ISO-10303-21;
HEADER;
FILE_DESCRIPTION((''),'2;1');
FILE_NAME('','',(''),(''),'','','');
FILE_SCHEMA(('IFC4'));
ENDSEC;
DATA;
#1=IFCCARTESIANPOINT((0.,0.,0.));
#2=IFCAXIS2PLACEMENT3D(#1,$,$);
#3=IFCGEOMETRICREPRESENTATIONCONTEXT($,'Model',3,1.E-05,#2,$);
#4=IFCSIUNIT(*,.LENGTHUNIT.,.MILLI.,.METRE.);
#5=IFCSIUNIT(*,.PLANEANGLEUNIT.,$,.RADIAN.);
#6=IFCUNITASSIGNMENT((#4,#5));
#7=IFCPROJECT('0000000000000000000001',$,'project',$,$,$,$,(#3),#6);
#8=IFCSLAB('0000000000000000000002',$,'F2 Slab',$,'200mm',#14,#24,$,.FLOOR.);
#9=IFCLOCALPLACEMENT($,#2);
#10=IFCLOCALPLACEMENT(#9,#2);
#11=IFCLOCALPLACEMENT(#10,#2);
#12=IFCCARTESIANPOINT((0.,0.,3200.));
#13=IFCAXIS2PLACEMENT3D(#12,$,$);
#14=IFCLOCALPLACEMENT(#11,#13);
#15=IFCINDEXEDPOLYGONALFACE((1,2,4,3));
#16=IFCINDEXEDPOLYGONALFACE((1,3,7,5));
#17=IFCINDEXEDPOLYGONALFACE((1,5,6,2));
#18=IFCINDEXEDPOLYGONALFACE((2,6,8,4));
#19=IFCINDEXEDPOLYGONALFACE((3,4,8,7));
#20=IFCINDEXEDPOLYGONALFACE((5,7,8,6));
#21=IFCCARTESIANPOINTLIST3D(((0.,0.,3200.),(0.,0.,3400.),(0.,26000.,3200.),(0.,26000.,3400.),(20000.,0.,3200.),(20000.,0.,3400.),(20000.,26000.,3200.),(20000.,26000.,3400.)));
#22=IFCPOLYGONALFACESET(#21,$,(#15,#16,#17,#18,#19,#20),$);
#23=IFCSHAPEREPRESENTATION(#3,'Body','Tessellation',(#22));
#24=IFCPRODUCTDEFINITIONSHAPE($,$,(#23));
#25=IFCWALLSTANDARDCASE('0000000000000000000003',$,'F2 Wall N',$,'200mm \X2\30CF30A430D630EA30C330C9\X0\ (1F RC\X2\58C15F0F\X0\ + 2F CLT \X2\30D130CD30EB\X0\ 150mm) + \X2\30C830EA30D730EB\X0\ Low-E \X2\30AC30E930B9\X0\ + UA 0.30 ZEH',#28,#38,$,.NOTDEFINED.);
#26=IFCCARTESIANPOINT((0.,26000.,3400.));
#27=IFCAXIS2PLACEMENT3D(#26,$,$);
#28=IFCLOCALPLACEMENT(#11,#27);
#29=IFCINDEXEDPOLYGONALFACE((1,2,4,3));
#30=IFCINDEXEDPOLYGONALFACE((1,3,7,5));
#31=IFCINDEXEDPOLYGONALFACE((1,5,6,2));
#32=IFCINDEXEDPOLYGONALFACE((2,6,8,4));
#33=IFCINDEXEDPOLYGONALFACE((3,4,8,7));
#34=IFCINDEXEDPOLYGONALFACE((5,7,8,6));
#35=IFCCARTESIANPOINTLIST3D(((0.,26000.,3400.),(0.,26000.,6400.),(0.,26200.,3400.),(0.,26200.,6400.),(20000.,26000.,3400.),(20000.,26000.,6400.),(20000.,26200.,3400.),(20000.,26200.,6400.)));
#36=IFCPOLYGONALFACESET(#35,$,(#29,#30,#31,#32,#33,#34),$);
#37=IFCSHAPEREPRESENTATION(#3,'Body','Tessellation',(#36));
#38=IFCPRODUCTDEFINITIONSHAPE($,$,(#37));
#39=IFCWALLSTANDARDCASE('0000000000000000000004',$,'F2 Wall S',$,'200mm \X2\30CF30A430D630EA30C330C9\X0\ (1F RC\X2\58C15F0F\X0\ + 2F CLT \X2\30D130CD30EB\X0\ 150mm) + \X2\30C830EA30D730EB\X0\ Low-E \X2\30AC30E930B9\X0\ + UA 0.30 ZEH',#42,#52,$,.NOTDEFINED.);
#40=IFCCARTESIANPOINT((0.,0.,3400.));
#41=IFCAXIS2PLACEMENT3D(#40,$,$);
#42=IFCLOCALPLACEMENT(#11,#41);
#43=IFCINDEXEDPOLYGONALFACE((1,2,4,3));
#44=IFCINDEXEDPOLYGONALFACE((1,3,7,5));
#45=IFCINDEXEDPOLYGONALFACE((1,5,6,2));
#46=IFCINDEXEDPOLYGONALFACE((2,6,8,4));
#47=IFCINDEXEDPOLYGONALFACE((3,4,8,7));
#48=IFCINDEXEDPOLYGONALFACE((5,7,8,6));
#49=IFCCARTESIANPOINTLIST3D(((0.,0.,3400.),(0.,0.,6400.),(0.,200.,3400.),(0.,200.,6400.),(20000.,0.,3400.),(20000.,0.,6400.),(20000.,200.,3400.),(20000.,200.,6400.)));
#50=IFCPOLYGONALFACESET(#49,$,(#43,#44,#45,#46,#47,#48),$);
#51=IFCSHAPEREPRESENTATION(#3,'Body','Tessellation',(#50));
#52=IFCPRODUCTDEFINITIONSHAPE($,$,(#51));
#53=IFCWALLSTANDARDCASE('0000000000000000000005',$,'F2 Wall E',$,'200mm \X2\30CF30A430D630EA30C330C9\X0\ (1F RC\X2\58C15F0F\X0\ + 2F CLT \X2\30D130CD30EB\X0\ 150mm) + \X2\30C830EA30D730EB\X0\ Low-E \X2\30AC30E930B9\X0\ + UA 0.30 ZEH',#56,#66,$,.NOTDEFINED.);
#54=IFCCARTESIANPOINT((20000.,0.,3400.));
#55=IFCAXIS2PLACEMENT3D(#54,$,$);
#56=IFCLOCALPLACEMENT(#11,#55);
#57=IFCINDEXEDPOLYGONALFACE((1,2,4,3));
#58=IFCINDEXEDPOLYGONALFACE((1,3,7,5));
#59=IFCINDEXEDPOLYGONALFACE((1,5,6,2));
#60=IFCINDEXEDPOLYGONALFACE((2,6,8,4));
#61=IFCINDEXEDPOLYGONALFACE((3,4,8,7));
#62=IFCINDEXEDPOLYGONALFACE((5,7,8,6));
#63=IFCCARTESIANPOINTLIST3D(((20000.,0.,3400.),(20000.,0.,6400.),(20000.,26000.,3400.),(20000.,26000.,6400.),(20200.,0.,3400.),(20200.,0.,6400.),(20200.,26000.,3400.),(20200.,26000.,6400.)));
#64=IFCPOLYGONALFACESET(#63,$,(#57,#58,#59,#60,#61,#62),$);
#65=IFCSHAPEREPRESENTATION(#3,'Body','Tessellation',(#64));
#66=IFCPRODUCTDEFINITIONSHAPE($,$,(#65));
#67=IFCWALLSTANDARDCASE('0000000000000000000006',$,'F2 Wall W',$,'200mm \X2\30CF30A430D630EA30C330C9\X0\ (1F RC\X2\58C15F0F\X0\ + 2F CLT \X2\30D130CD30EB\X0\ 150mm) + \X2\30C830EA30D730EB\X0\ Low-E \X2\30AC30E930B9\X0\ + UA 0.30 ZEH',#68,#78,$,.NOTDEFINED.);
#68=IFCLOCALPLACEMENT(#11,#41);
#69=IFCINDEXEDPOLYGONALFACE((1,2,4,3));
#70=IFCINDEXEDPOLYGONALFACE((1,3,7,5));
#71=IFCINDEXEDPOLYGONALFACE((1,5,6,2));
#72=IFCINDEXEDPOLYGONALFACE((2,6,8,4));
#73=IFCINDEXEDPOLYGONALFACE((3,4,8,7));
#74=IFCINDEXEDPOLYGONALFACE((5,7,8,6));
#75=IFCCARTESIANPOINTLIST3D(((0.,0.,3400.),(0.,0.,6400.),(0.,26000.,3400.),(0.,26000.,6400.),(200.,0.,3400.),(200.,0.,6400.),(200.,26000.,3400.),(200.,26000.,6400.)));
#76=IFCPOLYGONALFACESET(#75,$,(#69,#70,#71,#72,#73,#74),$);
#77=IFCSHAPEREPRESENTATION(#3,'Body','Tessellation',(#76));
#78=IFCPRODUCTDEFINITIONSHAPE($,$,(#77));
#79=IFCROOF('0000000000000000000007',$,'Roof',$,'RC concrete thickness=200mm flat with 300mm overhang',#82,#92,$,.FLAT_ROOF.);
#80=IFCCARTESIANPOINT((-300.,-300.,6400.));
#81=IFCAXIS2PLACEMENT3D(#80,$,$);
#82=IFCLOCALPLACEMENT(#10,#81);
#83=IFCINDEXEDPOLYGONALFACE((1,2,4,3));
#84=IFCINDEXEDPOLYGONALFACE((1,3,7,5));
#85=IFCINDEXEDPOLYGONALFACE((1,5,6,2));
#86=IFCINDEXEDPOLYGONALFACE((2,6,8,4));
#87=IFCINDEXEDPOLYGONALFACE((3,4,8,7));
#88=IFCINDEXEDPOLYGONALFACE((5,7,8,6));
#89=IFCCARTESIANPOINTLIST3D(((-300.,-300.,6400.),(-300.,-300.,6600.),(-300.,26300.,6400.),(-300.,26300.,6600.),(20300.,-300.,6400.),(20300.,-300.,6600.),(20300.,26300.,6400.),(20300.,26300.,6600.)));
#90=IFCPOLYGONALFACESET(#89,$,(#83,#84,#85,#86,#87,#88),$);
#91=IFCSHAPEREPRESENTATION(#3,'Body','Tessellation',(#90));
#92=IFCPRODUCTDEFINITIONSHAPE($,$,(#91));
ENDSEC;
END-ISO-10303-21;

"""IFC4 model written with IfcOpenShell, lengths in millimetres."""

from ifc_helpers import new_model, si_unit, frame, frame_2d, origin, place, context, project, rectangle, extrude, element, save


model = new_model("IFC4")

# Units and contexts
model_context = context("Model", 3, precision=1e-05, world=origin())
ifc_project = project(units=[si_unit("LENGTHUNIT", "METRE", prefix="MILLI"), si_unit("PLANEANGLEUNIT", "RADIAN")], contexts=[model_context])

# Slab
placement_1 = place(None, origin())
placement_2 = place(placement_1, origin())
placement_3 = place(placement_2, origin())
slab_placement = place(placement_3, frame((0.0, 0.0, 3200.0)))
element("IfcSlab", 1, at=slab_placement, Name="F2 Slab", ObjectType="200mm", PredefinedType="FLOOR", context=model_context, shape_type="SweptSolid", body=[
    extrude(rectangle(XDim=20000.0, YDim=26000.0, at=frame_2d((10000.0, 13000.0))), frame((0.0, 0.0, 3200.0)), (0.0, 0.0, 1.0), 200.0),
])

# Walls
wall_1_placement = place(placement_3, frame((0.0, 26000.0, 3400.0)))
element("IfcWallStandardCase", 2, at=wall_1_placement, Name="F2 Wall N", ObjectType="200mm ハイブリッド (1F RC壁式 + 2F CLT パネル 150mm) + トリプル Low-E ガラス + UA 0.30 ZEH", PredefinedType="NOTDEFINED", context=model_context, shape_type="SweptSolid", body=[
    extrude(rectangle(XDim=20000.0, YDim=200.0, at=frame_2d((10000.0, 100.0))), frame((0.0, 26000.0, 3400.0)), (0.0, 0.0, 1.0), 3000.0),
])
wall_2_placement = place(placement_3, frame((0.0, 0.0, 3400.0)))
element("IfcWallStandardCase", 3, at=wall_2_placement, Name="F2 Wall S", ObjectType="200mm ハイブリッド (1F RC壁式 + 2F CLT パネル 150mm) + トリプル Low-E ガラス + UA 0.30 ZEH", PredefinedType="NOTDEFINED", context=model_context, shape_type="SweptSolid", body=[
    extrude(rectangle(XDim=20000.0, YDim=200.0, at=frame_2d((10000.0, 100.0))), frame((0.0, 0.0, 3400.0)), (0.0, 0.0, 1.0), 3000.0),
])
wall_3_placement = place(placement_3, frame((20000.0, 0.0, 3400.0)))
element("IfcWallStandardCase", 4, at=wall_3_placement, Name="F2 Wall E", ObjectType="200mm ハイブリッド (1F RC壁式 + 2F CLT パネル 150mm) + トリプル Low-E ガラス + UA 0.30 ZEH", PredefinedType="NOTDEFINED", context=model_context, shape_type="SweptSolid", body=[
    extrude(rectangle(XDim=200.0, YDim=26000.0, at=frame_2d((100.0, 13000.0))), frame((20000.0, 0.0, 3400.0)), (0.0, 0.0, 1.0), 3000.0),
])
wall_4_placement = place(placement_3, frame((0.0, 0.0, 3400.0)))
element("IfcWallStandardCase", 5, at=wall_4_placement, Name="F2 Wall W", ObjectType="200mm ハイブリッド (1F RC壁式 + 2F CLT パネル 150mm) + トリプル Low-E ガラス + UA 0.30 ZEH", PredefinedType="NOTDEFINED", context=model_context, shape_type="SweptSolid", body=[
    extrude(rectangle(XDim=200.0, YDim=26000.0, at=frame_2d((100.0, 13000.0))), frame((0.0, 0.0, 3400.0)), (0.0, 0.0, 1.0), 3000.0),
])

# Roof
roof_placement = place(placement_2, frame((-300.0, -300.0, 6400.0)))
element("IfcRoof", 6, at=roof_placement, Name="Roof", ObjectType="RC concrete thickness=200mm flat with 300mm overhang", PredefinedType="FLAT_ROOF", context=model_context, shape_type="SweptSolid", body=[
    extrude(rectangle(XDim=20600.0, YDim=26600.0, at=frame_2d((10300.0, 13300.0))), frame((-300.0, -300.0, 6400.0)), (0.0, 0.0, 1.0), 200.0),
])

save(model, "model.ifc")
